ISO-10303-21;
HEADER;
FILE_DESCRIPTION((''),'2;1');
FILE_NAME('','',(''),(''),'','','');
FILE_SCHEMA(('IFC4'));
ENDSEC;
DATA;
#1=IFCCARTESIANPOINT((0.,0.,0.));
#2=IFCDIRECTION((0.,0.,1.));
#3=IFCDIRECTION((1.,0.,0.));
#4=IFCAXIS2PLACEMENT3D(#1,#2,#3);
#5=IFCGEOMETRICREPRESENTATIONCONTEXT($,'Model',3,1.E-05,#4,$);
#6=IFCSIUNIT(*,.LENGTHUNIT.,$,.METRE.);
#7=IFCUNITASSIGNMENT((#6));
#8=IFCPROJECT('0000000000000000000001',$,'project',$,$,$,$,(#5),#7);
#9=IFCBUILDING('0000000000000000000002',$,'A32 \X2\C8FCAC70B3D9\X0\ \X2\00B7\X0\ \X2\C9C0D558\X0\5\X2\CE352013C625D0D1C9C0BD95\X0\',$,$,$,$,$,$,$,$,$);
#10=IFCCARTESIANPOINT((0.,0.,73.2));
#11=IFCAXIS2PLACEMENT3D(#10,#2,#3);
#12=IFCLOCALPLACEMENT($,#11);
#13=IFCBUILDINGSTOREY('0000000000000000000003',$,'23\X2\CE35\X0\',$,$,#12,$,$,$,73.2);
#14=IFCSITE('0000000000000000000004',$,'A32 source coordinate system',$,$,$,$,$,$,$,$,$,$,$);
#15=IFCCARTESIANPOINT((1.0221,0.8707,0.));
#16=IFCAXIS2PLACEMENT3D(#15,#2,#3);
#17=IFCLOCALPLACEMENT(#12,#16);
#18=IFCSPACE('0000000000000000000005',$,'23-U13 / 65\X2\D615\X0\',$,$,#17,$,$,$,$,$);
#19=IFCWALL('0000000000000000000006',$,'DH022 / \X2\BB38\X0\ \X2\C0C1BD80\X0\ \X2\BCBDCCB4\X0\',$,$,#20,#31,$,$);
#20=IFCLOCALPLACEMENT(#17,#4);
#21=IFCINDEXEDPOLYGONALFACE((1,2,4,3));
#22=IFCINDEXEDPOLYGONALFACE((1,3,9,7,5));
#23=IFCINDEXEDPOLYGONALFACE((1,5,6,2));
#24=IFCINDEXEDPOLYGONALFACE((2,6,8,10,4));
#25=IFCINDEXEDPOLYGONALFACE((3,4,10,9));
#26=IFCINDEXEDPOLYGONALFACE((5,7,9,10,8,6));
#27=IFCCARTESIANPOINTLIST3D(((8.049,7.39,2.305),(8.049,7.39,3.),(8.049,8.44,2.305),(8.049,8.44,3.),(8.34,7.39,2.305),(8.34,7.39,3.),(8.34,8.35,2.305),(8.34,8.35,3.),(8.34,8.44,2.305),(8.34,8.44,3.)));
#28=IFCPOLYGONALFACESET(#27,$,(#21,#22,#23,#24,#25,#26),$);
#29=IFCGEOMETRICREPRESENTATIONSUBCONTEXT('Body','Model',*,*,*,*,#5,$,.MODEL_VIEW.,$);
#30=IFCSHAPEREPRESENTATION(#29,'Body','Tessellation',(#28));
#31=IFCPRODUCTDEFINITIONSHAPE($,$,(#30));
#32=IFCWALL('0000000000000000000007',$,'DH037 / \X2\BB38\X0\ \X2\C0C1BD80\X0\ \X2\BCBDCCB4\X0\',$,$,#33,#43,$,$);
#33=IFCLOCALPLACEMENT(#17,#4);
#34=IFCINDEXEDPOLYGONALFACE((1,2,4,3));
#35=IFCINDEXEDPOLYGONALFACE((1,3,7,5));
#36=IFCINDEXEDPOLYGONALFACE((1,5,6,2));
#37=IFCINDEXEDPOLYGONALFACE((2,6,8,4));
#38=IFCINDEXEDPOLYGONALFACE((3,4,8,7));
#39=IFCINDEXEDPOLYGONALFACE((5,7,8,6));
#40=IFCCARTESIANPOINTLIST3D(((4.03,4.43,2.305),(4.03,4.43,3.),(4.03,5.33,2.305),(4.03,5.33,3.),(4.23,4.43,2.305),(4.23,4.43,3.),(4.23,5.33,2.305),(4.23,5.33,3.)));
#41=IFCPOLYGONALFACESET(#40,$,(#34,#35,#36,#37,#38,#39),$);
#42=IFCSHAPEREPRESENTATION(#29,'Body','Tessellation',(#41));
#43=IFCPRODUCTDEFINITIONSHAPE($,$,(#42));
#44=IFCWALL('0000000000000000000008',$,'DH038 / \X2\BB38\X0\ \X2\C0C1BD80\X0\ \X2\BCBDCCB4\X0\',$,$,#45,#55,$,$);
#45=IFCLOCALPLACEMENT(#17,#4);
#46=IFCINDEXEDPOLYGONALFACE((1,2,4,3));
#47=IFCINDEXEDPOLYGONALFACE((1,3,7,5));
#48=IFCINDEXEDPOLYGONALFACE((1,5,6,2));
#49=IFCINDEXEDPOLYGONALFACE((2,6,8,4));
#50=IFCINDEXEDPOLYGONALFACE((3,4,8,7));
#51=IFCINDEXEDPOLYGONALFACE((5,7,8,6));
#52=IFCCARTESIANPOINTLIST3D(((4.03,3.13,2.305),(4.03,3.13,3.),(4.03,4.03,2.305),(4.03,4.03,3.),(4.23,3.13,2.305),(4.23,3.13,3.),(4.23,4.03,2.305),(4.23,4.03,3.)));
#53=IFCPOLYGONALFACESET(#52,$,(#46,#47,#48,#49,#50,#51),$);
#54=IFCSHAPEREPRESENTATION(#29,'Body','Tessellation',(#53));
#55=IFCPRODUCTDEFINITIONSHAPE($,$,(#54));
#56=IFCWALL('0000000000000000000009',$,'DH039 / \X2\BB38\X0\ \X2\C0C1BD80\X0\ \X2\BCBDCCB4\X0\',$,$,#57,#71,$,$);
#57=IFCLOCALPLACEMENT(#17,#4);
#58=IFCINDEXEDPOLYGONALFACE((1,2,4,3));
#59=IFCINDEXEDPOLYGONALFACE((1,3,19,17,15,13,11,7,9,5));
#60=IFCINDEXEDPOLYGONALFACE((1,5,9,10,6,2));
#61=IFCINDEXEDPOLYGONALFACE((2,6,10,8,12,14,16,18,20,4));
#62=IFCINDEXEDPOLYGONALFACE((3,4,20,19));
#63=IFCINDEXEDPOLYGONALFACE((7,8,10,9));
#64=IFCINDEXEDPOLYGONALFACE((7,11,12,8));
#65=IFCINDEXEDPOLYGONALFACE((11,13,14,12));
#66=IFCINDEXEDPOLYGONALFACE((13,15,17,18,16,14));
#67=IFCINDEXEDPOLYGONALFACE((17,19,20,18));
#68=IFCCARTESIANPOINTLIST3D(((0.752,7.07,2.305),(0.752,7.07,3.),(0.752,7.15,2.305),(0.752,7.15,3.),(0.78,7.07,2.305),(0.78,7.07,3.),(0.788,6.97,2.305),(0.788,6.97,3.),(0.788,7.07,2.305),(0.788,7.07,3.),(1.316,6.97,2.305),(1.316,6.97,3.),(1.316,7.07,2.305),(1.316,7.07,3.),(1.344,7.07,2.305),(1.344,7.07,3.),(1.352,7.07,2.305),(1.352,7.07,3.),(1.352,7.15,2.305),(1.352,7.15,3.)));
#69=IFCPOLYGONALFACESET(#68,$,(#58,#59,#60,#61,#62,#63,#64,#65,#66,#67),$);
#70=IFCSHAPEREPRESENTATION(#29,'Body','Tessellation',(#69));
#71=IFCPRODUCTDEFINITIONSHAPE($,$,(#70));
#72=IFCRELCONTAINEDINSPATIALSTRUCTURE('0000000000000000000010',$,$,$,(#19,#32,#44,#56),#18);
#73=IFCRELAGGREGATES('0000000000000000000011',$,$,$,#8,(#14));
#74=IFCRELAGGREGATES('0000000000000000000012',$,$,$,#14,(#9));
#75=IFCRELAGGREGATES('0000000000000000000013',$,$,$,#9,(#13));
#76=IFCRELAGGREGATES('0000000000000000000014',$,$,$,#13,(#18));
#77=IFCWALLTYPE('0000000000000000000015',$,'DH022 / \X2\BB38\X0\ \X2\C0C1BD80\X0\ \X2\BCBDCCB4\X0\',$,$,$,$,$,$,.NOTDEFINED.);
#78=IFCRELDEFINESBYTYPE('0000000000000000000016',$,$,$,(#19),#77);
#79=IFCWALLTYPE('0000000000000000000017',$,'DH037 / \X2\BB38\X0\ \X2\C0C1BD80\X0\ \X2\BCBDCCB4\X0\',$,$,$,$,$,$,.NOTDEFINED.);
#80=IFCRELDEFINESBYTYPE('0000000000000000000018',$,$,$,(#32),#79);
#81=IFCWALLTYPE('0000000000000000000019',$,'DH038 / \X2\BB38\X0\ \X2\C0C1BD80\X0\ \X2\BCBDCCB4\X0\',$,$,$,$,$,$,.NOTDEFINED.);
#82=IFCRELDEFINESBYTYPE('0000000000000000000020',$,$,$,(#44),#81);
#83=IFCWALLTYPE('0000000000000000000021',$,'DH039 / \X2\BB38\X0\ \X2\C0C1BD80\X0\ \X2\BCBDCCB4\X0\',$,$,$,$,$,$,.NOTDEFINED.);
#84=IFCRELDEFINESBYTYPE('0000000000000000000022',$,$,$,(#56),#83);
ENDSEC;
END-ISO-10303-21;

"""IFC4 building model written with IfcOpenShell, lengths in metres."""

from ifc_helpers import new_model, si_unit, frame, origin, origin_with_axes, place, context, subcontext, project, spatial, polyline, outline, extrude, source, transform, mapped, type_object, type_shapes, element, save


model = new_model("IFC4")

# Units and contexts
model_context = context("Model", 3, precision=1e-05, world=origin_with_axes())
body_context = subcontext(model_context, "Body", "Model", "MODEL_VIEW")
ifc_project = project(units=[si_unit("LENGTHUNIT", "METRE")], contexts=[model_context])

# Site, building, storey, space
site = spatial("IfcSite", under=ifc_project, Name="A32 source coordinate system")
building = spatial("IfcBuilding", under=site, Name="A32 주거동 · 지하5층–옥탑지붕")
storey_placement = place(None, frame((0.0, 0.0, 73.2), z_axis=(0.0, 0.0, 1.0), x_axis=(1.0, 0.0, 0.0)))
storey = spatial("IfcBuildingStorey", under=building, at=storey_placement, Name="23층", Elevation=73.2)
space_placement = place(storey_placement, frame((1.0221, 0.8707, 0.0), z_axis=(0.0, 0.0, 1.0), x_axis=(1.0, 0.0, 0.0)))
space = spatial("IfcSpace", under=storey, at=space_placement, Name="23-U13 / 65형")

# Walls
wall_type_1 = type_object("IfcWallType", Name="DH022 / 문 상부 벽체", PredefinedType="NOTDEFINED")
shared_shape_1 = source(origin(), body_context, "Body", "SweptSolid", [
    extrude(outline(polyline([(8.049, 7.39), (8.049, 8.44), (8.34, 8.44), (8.34, 8.35), (8.34, 8.35), (8.34, 7.39), (8.049, 7.39)])), frame((0.0, 0.0, 2.305)), (0.0, 0.0, 1.0), 0.695),
])
type_shapes(wall_type_1, [shared_shape_1])
wall_1_placement = place(space_placement, origin_with_axes())
element("IfcWall", 1, at=wall_1_placement, inside=space, type_object=wall_type_1, Name="DH022 / 문 상부 벽체", context=body_context, shape_type="MappedRepresentation", body=[
    mapped(shared_shape_1, transform((0.0, 0.0, 0.0), scale=1.0)),
])
wall_type_2 = type_object("IfcWallType", Name="DH037 / 문 상부 벽체", PredefinedType="NOTDEFINED")
shared_shape_2 = source(origin(), body_context, "Body", "SweptSolid", [
    extrude(outline(polyline([(4.23, 5.33), (4.23, 4.43), (4.03, 4.43), (4.03, 5.33), (4.23, 5.33)])), frame((0.0, 0.0, 2.305)), (0.0, 0.0, 1.0), 0.695),
])
type_shapes(wall_type_2, [shared_shape_2])
wall_2_placement = place(space_placement, origin_with_axes())
element("IfcWall", 2, at=wall_2_placement, inside=space, type_object=wall_type_2, Name="DH037 / 문 상부 벽체", context=body_context, shape_type="MappedRepresentation", body=[
    mapped(shared_shape_2, transform((0.0, 0.0, 0.0), scale=1.0)),
])
wall_type_3 = type_object("IfcWallType", Name="DH038 / 문 상부 벽체", PredefinedType="NOTDEFINED")
shared_shape_3 = source(origin(), body_context, "Body", "SweptSolid", [
    extrude(outline(polyline([(4.23, 4.03), (4.23, 3.13), (4.03, 3.13), (4.03, 4.03), (4.23, 4.03)])), frame((0.0, 0.0, 2.305)), (0.0, 0.0, 1.0), 0.695),
])
type_shapes(wall_type_3, [shared_shape_3])
wall_3_placement = place(space_placement, origin_with_axes())
element("IfcWall", 3, at=wall_3_placement, inside=space, type_object=wall_type_3, Name="DH038 / 문 상부 벽체", context=body_context, shape_type="MappedRepresentation", body=[
    mapped(shared_shape_3, transform((0.0, 0.0, 0.0), scale=1.0)),
])
wall_type_4 = type_object("IfcWallType", Name="DH039 / 문 상부 벽체", PredefinedType="NOTDEFINED")
shared_shape_4 = source(origin(), body_context, "Body", "SweptSolid", [
    extrude(outline(polyline([(1.316, 7.07), (1.316, 6.97), (0.788, 6.97), (0.788, 7.07), (0.78, 7.07), (0.752, 7.07), (0.752, 7.15), (1.352, 7.15), (1.352, 7.07), (1.344, 7.07), (1.316, 7.07)])), frame((0.0, 0.0, 2.305)), (0.0, 0.0, 1.0), 0.695),
])
type_shapes(wall_type_4, [shared_shape_4])
wall_4_placement = place(space_placement, origin_with_axes())
element("IfcWall", 4, at=wall_4_placement, inside=space, type_object=wall_type_4, Name="DH039 / 문 상부 벽체", context=body_context, shape_type="MappedRepresentation", body=[
    mapped(shared_shape_4, transform((0.0, 0.0, 0.0), scale=1.0)),
])

save(model, "model.ifc")
